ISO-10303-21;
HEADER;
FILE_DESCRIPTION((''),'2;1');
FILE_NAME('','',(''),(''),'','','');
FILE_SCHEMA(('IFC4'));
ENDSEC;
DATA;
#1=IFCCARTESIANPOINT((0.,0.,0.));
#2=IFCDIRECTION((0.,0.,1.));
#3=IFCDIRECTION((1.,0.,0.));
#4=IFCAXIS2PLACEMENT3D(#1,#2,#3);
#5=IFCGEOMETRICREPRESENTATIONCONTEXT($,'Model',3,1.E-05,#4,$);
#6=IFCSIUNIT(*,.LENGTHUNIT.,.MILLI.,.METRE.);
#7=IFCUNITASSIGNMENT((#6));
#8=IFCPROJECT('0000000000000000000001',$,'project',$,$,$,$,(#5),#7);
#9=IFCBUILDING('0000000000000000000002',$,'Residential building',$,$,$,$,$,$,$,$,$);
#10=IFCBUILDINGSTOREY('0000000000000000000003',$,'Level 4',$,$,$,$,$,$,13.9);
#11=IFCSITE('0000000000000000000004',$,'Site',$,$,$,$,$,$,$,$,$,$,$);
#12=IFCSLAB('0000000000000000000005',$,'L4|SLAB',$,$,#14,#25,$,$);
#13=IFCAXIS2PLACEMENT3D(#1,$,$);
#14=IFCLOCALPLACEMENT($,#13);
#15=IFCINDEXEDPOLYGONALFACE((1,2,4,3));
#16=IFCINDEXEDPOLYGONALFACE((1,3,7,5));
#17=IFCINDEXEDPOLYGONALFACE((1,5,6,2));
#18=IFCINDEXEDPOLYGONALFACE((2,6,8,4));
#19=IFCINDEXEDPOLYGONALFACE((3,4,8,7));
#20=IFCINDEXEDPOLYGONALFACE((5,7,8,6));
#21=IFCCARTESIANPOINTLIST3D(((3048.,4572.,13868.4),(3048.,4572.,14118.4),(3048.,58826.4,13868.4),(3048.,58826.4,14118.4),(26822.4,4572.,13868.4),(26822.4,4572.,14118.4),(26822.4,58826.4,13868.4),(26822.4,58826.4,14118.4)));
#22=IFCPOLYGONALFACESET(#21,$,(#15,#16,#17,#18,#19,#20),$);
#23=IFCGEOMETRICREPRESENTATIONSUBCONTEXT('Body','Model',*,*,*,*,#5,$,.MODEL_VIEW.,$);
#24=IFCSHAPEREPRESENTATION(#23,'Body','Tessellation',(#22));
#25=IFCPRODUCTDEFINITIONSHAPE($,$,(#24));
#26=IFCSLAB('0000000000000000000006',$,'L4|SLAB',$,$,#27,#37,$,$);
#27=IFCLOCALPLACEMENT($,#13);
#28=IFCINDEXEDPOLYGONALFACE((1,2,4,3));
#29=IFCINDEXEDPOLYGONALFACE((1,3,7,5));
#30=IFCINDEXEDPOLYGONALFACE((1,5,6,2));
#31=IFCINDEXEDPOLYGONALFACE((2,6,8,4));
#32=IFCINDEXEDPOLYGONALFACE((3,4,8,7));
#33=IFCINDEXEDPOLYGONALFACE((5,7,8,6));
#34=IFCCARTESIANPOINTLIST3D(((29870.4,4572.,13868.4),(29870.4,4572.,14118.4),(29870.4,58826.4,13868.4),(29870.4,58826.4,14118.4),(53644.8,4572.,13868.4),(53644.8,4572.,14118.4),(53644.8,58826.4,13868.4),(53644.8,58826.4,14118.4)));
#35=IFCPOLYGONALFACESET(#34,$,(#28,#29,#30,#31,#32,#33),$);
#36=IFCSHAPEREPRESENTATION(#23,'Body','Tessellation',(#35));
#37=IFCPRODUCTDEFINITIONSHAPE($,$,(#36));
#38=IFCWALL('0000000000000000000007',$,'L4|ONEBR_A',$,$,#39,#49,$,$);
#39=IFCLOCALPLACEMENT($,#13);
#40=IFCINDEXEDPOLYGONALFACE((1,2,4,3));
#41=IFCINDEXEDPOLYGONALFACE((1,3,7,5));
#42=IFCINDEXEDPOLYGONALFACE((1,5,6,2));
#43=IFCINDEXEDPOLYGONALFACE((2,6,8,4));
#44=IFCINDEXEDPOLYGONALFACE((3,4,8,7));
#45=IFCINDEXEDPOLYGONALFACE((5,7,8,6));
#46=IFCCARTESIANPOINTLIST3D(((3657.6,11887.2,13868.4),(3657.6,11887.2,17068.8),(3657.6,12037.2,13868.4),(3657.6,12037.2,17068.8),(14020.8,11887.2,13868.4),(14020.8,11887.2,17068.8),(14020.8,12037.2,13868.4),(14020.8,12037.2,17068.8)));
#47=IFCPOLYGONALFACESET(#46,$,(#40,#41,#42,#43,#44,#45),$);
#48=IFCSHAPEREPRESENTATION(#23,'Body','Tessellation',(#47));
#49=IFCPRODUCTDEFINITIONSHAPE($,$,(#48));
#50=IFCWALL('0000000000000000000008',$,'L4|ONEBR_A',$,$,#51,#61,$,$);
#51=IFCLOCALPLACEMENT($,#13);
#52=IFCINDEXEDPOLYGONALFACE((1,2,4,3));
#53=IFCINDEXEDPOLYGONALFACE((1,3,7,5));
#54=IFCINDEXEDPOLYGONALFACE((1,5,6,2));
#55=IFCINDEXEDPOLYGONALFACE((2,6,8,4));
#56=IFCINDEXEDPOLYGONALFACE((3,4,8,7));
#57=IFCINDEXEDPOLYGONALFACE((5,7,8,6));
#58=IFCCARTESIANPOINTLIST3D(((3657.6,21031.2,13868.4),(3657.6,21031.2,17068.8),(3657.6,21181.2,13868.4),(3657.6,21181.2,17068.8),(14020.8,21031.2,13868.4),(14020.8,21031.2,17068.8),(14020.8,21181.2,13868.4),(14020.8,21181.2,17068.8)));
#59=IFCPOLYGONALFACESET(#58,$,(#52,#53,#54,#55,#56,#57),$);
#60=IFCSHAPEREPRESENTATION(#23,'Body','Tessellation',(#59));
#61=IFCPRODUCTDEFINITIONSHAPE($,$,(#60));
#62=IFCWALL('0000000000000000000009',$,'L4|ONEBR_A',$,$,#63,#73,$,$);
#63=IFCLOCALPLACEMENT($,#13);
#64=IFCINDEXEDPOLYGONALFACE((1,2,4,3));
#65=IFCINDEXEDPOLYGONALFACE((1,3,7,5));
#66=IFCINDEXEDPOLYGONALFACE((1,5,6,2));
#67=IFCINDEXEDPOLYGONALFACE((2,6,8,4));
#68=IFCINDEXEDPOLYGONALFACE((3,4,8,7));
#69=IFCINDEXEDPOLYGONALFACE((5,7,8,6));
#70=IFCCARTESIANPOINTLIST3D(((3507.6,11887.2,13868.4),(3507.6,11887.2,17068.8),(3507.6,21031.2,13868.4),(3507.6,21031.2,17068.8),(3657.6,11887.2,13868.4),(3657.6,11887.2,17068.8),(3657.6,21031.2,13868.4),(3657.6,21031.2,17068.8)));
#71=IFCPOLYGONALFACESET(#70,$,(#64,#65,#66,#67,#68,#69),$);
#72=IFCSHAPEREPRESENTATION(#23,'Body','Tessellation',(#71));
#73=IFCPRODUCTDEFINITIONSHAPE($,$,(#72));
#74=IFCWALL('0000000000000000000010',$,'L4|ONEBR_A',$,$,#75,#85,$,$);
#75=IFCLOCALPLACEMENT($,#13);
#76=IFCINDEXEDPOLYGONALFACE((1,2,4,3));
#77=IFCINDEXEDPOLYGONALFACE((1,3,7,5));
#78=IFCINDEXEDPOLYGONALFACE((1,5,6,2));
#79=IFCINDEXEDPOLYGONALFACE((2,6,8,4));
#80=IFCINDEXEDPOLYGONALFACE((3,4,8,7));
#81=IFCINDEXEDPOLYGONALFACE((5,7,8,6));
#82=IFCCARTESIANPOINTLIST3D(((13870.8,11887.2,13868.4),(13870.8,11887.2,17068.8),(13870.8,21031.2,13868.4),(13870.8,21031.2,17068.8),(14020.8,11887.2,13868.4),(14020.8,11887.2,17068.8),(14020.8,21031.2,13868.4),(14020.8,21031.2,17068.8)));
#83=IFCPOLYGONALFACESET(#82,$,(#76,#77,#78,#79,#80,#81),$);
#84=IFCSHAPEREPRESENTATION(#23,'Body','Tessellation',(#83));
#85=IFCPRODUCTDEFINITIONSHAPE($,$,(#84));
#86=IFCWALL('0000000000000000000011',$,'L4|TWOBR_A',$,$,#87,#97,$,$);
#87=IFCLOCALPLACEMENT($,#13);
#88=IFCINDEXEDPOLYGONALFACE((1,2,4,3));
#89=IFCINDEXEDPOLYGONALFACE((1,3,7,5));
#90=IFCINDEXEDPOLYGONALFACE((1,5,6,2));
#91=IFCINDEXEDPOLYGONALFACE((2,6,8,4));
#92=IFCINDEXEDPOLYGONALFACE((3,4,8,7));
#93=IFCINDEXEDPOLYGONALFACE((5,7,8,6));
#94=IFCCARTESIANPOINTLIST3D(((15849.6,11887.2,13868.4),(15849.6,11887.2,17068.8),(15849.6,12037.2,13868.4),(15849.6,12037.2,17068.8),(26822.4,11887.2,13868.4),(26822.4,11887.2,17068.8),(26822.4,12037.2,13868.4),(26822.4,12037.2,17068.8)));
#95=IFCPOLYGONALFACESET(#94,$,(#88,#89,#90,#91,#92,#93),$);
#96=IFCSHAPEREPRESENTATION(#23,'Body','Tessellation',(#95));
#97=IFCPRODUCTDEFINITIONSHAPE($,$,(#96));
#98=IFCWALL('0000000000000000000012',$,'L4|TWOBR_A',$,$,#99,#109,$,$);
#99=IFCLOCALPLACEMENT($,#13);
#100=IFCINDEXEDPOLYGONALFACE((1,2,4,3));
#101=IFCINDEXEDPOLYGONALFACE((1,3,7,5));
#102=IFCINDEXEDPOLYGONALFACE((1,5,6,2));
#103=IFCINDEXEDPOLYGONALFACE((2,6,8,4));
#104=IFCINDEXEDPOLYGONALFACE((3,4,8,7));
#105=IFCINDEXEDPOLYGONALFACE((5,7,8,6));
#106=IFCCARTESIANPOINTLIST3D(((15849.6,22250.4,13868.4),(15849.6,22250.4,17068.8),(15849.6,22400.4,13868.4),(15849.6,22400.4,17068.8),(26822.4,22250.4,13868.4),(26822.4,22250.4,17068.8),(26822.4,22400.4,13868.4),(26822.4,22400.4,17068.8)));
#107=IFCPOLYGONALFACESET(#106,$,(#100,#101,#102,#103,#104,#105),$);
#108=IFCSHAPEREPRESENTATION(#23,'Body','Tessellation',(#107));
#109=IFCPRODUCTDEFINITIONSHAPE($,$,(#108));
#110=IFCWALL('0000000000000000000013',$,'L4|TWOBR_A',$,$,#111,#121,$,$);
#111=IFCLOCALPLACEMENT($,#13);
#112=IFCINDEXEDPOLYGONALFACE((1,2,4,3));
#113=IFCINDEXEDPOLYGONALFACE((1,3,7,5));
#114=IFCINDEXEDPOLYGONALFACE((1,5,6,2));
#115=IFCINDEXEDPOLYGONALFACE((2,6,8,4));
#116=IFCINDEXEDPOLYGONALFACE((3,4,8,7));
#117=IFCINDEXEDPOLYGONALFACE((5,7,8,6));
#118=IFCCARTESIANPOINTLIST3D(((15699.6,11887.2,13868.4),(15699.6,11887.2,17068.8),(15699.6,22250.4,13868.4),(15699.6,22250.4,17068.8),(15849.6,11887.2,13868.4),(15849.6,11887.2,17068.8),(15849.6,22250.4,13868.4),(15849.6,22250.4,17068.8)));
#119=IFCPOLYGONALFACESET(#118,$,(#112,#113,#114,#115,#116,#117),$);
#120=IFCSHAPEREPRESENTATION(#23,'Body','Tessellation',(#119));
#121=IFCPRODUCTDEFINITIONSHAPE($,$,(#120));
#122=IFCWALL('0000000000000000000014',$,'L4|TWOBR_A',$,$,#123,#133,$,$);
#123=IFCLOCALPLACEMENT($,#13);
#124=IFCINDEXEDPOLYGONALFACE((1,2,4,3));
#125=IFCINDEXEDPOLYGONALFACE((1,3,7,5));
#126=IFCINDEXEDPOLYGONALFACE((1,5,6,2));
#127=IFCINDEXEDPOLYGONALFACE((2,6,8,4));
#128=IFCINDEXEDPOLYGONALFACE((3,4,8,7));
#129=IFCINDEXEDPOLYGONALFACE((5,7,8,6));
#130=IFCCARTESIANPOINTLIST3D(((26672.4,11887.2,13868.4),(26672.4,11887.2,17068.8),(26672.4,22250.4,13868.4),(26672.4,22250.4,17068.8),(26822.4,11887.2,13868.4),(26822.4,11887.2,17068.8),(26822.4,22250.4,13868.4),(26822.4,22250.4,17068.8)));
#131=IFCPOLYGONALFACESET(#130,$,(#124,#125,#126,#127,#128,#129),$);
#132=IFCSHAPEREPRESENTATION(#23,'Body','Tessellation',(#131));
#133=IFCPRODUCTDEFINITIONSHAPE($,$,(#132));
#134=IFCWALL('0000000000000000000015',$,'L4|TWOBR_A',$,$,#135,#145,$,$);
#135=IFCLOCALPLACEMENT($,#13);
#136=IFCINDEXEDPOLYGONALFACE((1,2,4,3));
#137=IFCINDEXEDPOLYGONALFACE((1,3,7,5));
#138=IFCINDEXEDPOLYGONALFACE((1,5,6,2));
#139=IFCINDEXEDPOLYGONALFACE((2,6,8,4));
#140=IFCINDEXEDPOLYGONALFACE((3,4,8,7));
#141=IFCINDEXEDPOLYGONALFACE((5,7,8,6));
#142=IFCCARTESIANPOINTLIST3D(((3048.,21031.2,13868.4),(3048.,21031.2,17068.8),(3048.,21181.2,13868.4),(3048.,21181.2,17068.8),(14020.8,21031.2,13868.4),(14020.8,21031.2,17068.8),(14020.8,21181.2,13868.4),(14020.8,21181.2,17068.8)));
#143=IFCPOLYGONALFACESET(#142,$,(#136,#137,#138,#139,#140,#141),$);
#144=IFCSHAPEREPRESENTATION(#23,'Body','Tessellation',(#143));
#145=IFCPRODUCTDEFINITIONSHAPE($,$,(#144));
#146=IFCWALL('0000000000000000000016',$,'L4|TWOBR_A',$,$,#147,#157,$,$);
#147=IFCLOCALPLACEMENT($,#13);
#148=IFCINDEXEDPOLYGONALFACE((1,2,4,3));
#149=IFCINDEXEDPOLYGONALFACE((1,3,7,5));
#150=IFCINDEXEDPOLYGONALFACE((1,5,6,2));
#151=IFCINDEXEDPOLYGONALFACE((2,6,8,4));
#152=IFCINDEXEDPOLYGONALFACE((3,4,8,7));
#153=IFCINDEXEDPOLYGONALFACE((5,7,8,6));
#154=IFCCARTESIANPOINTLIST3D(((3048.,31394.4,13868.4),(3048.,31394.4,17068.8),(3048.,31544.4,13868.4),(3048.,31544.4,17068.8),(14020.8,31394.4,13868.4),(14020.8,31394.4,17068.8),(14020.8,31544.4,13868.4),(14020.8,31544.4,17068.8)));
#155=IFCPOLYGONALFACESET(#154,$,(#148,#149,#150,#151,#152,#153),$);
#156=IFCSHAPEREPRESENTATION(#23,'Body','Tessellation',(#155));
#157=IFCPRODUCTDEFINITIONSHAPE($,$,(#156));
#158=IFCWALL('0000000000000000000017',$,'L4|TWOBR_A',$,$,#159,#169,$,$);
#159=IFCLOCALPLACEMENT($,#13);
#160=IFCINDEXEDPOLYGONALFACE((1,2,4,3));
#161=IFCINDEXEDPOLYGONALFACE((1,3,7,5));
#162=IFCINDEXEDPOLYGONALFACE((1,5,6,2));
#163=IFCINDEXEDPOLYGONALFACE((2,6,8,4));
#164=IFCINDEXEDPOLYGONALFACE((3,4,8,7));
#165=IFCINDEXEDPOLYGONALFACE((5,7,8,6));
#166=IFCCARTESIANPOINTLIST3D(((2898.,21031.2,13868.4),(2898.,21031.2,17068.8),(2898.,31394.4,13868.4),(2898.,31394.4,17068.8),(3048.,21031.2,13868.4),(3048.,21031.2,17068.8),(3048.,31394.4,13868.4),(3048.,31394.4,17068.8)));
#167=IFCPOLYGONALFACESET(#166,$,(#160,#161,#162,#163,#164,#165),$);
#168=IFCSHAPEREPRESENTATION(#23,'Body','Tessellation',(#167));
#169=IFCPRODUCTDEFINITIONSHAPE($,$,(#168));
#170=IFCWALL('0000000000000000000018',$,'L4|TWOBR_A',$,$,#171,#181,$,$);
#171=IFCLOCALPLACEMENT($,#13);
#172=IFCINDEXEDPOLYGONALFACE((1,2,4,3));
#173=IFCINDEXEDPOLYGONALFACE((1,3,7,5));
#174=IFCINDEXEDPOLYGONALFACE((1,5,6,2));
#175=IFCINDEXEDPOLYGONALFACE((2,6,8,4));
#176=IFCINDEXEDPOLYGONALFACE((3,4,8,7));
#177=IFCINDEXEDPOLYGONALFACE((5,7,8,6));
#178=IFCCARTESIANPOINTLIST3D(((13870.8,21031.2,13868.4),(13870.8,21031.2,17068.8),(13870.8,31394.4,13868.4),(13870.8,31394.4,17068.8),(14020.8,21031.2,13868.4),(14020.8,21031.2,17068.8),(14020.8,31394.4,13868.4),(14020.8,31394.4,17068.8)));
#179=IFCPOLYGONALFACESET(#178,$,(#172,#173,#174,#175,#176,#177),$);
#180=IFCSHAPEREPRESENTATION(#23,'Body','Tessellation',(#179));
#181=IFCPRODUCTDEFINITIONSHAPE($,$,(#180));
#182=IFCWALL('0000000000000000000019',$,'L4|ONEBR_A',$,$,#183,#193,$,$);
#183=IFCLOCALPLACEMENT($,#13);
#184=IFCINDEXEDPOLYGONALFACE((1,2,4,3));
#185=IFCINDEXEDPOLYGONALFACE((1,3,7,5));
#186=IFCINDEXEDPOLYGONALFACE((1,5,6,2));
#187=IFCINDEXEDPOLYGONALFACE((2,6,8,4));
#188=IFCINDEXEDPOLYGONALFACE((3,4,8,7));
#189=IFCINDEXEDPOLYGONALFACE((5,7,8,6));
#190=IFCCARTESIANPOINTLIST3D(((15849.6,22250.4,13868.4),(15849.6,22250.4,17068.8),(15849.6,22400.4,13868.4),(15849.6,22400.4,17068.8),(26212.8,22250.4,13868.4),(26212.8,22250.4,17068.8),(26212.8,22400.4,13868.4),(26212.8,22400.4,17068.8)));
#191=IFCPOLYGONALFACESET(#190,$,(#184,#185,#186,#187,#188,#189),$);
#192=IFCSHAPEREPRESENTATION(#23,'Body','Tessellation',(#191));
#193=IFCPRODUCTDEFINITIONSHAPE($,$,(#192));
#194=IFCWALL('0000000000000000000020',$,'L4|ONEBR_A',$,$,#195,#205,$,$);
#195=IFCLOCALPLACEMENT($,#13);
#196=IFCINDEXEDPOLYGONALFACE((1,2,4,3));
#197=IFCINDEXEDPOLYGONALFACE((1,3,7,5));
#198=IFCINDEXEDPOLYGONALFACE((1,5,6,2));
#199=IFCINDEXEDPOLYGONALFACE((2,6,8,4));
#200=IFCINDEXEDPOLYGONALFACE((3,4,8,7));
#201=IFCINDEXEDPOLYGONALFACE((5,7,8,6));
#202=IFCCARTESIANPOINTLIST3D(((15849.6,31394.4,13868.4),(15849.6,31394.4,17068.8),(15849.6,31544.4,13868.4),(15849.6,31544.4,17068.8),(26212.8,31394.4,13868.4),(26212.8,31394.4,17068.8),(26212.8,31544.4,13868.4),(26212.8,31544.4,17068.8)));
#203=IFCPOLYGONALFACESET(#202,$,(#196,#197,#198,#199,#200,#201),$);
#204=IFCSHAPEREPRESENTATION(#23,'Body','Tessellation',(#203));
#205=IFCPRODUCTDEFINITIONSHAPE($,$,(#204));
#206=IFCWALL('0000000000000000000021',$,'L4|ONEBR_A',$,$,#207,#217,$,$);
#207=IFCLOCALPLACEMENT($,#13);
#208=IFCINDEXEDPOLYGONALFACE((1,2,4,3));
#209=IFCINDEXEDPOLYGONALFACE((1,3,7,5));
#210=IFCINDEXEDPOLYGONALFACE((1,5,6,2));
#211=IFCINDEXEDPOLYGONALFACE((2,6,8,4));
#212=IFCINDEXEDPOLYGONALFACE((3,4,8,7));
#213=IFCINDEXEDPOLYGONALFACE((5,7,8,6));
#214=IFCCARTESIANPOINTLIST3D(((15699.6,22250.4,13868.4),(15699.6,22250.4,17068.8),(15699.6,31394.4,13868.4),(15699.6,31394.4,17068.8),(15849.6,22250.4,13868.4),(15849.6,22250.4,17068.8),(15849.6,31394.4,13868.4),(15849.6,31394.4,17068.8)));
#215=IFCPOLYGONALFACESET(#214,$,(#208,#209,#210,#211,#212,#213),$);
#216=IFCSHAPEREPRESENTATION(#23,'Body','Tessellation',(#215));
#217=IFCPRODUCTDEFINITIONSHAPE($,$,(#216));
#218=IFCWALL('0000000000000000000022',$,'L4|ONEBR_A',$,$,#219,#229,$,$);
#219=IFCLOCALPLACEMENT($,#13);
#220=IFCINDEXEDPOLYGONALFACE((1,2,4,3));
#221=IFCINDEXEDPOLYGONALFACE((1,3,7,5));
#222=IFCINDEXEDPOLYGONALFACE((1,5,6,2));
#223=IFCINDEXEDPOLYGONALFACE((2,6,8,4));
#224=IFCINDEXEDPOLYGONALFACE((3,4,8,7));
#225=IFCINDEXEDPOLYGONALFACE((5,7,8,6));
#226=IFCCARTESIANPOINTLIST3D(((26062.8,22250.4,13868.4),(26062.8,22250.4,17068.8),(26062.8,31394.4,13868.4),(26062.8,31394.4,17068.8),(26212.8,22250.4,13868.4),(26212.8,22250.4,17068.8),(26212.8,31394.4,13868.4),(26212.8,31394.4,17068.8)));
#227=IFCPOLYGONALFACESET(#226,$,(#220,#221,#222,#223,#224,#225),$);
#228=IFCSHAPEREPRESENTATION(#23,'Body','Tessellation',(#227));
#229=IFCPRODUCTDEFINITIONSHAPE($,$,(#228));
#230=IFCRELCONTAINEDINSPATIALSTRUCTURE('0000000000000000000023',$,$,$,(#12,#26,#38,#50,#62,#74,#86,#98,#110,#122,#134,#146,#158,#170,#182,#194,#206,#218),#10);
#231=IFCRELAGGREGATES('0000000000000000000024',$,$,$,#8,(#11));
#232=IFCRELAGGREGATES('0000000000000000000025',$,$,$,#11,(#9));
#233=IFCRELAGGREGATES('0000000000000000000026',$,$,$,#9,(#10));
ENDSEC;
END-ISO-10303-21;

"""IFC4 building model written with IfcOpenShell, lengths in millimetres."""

from ifc_helpers import new_model, si_unit, frame, origin_with_axes, place, context, subcontext, project, spatial, indexed_curve, outline, extrude, element, save


model = new_model("IFC4")

# Units and contexts
model_context = context("Model", 3, precision=1e-05, world=origin_with_axes())
body_context = subcontext(model_context, "Body", "Model", "MODEL_VIEW")
ifc_project = project(units=[si_unit("LENGTHUNIT", "METRE", prefix="MILLI")], contexts=[model_context])

# Site, building, storey
site = spatial("IfcSite", under=ifc_project, Name="Site")
building = spatial("IfcBuilding", under=site, Name="Residential building")
storey = spatial("IfcBuildingStorey", under=building, Name="Level 4", Elevation=13.9)

# Slabs
for number, where, z_axis, x_axis, name in (
    (1, (3048.0, 4572.0, 13868.4), (0.0, 0.0, 1.0), (1.0, 0.0, 0.0), "L4|SLAB"),
    (2, (29870.4, 4572.0, 13868.4), (0.0, 0.0, 1.0), (1.0, 0.0, 0.0), "L4|SLAB"),
):
    element("IfcSlab", number, at=place(None, frame(where, z_axis=z_axis, x_axis=x_axis)), inside=storey, Name=name, context=body_context, shape_type="SweptSolid", body=[
        extrude(outline(indexed_curve([(0.0, 0.0), (23774.4, 0.0), (23774.4, 54254.4), (0.0, 54254.4), (0.0, 0.0)])), None, (0.0, 0.0, 1.0), 250.0),
    ])

# Walls
for number, where, z_axis, x_axis, name in (
    (3, (3657.6, 11887.2, 13868.4), (0.0, 0.0, 1.0), (1.0, 0.0, 0.0), "L4|ONEBR_A"),
    (4, (3657.6, 21031.2, 13868.4), (0.0, 0.0, 1.0), (1.0, 0.0, 0.0), "L4|ONEBR_A"),
):
    element("IfcWall", number, at=place(None, frame(where, z_axis=z_axis, x_axis=x_axis)), inside=storey, Name=name, context=body_context, shape_type="SweptSolid", body=[
        extrude(outline(indexed_curve([(0.0, 0.0), (0.0, 150.0), (10363.2, 150.0), (10363.2, 0.0), (0.0, 0.0)], self_intersect=False)), origin_with_axes(), (0.0, 0.0, 1.0), 3200.4),
    ])
for number, where, z_axis, x_axis, name in (
    (5, (3657.6, 11887.2, 13868.4), (0.0, 0.0, 1.0), (0.0, 1.0, 0.0), "L4|ONEBR_A"),
    (6, (14020.8, 11887.2, 13868.4), (0.0, 0.0, 1.0), (0.0, 1.0, 0.0), "L4|ONEBR_A"),
):
    element("IfcWall", number, at=place(None, frame(where, z_axis=z_axis, x_axis=x_axis)), inside=storey, Name=name, context=body_context, shape_type="SweptSolid", body=[
        extrude(outline(indexed_curve([(0.0, 0.0), (0.0, 150.0), (9144.0, 150.0), (9144.0, 0.0), (0.0, 0.0)], self_intersect=False)), origin_with_axes(), (0.0, 0.0, 1.0), 3200.4),
    ])
for number, where, z_axis, x_axis, name in (
    (7, (15849.6, 11887.2, 13868.4), (0.0, 0.0, 1.0), (1.0, 0.0, 0.0), "L4|TWOBR_A"),
    (8, (15849.6, 22250.4, 13868.4), (0.0, 0.0, 1.0), (1.0, 0.0, 0.0), "L4|TWOBR_A"),
):
    element("IfcWall", number, at=place(None, frame(where, z_axis=z_axis, x_axis=x_axis)), inside=storey, Name=name, context=body_context, shape_type="SweptSolid", body=[
        extrude(outline(indexed_curve([(0.0, 0.0), (0.0, 150.0), (10972.8, 150.0), (10972.8, 0.0), (0.0, 0.0)], self_intersect=False)), origin_with_axes(), (0.0, 0.0, 1.0), 3200.4),
    ])
for number, where, z_axis, x_axis, name in (
    (9, (15849.6, 11887.2, 13868.4), (0.0, 0.0, 1.0), (0.0, 1.0, 0.0), "L4|TWOBR_A"),
    (10, (26822.4, 11887.2, 13868.4), (0.0, 0.0, 1.0), (0.0, 1.0, 0.0), "L4|TWOBR_A"),
):
    element("IfcWall", number, at=place(None, frame(where, z_axis=z_axis, x_axis=x_axis)), inside=storey, Name=name, context=body_context, shape_type="SweptSolid", body=[
        extrude(outline(indexed_curve([(0.0, 0.0), (0.0, 150.0), (10363.2, 150.0), (10363.2, 0.0), (0.0, 0.0)], self_intersect=False)), origin_with_axes(), (0.0, 0.0, 1.0), 3200.4),
    ])
for number, where, z_axis, x_axis, name in (
    (11, (3048.0, 21031.2, 13868.4), (0.0, 0.0, 1.0), (1.0, 0.0, 0.0), "L4|TWOBR_A"),
    (12, (3048.0, 31394.4, 13868.4), (0.0, 0.0, 1.0), (1.0, 0.0, 0.0), "L4|TWOBR_A"),
):
    element("IfcWall", number, at=place(None, frame(where, z_axis=z_axis, x_axis=x_axis)), inside=storey, Name=name, context=body_context, shape_type="SweptSolid", body=[
        extrude(outline(indexed_curve([(0.0, 0.0), (0.0, 150.0), (10972.8, 150.0), (10972.8, 0.0), (0.0, 0.0)], self_intersect=False)), origin_with_axes(), (0.0, 0.0, 1.0), 3200.4),
    ])
for number, where, z_axis, x_axis, name in (
    (13, (3048.0, 21031.2, 13868.4), (0.0, 0.0, 1.0), (0.0, 1.0, 0.0), "L4|TWOBR_A"),
    (14, (14020.8, 21031.2, 13868.4), (0.0, 0.0, 1.0), (0.0, 1.0, 0.0), "L4|TWOBR_A"),
    (15, (15849.6, 22250.4, 13868.4), (0.0, 0.0, 1.0), (1.0, 0.0, 0.0), "L4|ONEBR_A"),
    (16, (15849.6, 31394.4, 13868.4), (0.0, 0.0, 1.0), (1.0, 0.0, 0.0), "L4|ONEBR_A"),
):
    element("IfcWall", number, at=place(None, frame(where, z_axis=z_axis, x_axis=x_axis)), inside=storey, Name=name, context=body_context, shape_type="SweptSolid", body=[
        extrude(outline(indexed_curve([(0.0, 0.0), (0.0, 150.0), (10363.2, 150.0), (10363.2, 0.0), (0.0, 0.0)], self_intersect=False)), origin_with_axes(), (0.0, 0.0, 1.0), 3200.4),
    ])
for number, where, z_axis, x_axis, name in (
    (17, (15849.6, 22250.4, 13868.4), (0.0, 0.0, 1.0), (0.0, 1.0, 0.0), "L4|ONEBR_A"),
    (18, (26212.8, 22250.4, 13868.4), (0.0, 0.0, 1.0), (0.0, 1.0, 0.0), "L4|ONEBR_A"),
):
    element("IfcWall", number, at=place(None, frame(where, z_axis=z_axis, x_axis=x_axis)), inside=storey, Name=name, context=body_context, shape_type="SweptSolid", body=[
        extrude(outline(indexed_curve([(0.0, 0.0), (0.0, 150.0), (9144.0, 150.0), (9144.0, 0.0), (0.0, 0.0)], self_intersect=False)), origin_with_axes(), (0.0, 0.0, 1.0), 3200.4),
    ])

save(model, "model.ifc")
